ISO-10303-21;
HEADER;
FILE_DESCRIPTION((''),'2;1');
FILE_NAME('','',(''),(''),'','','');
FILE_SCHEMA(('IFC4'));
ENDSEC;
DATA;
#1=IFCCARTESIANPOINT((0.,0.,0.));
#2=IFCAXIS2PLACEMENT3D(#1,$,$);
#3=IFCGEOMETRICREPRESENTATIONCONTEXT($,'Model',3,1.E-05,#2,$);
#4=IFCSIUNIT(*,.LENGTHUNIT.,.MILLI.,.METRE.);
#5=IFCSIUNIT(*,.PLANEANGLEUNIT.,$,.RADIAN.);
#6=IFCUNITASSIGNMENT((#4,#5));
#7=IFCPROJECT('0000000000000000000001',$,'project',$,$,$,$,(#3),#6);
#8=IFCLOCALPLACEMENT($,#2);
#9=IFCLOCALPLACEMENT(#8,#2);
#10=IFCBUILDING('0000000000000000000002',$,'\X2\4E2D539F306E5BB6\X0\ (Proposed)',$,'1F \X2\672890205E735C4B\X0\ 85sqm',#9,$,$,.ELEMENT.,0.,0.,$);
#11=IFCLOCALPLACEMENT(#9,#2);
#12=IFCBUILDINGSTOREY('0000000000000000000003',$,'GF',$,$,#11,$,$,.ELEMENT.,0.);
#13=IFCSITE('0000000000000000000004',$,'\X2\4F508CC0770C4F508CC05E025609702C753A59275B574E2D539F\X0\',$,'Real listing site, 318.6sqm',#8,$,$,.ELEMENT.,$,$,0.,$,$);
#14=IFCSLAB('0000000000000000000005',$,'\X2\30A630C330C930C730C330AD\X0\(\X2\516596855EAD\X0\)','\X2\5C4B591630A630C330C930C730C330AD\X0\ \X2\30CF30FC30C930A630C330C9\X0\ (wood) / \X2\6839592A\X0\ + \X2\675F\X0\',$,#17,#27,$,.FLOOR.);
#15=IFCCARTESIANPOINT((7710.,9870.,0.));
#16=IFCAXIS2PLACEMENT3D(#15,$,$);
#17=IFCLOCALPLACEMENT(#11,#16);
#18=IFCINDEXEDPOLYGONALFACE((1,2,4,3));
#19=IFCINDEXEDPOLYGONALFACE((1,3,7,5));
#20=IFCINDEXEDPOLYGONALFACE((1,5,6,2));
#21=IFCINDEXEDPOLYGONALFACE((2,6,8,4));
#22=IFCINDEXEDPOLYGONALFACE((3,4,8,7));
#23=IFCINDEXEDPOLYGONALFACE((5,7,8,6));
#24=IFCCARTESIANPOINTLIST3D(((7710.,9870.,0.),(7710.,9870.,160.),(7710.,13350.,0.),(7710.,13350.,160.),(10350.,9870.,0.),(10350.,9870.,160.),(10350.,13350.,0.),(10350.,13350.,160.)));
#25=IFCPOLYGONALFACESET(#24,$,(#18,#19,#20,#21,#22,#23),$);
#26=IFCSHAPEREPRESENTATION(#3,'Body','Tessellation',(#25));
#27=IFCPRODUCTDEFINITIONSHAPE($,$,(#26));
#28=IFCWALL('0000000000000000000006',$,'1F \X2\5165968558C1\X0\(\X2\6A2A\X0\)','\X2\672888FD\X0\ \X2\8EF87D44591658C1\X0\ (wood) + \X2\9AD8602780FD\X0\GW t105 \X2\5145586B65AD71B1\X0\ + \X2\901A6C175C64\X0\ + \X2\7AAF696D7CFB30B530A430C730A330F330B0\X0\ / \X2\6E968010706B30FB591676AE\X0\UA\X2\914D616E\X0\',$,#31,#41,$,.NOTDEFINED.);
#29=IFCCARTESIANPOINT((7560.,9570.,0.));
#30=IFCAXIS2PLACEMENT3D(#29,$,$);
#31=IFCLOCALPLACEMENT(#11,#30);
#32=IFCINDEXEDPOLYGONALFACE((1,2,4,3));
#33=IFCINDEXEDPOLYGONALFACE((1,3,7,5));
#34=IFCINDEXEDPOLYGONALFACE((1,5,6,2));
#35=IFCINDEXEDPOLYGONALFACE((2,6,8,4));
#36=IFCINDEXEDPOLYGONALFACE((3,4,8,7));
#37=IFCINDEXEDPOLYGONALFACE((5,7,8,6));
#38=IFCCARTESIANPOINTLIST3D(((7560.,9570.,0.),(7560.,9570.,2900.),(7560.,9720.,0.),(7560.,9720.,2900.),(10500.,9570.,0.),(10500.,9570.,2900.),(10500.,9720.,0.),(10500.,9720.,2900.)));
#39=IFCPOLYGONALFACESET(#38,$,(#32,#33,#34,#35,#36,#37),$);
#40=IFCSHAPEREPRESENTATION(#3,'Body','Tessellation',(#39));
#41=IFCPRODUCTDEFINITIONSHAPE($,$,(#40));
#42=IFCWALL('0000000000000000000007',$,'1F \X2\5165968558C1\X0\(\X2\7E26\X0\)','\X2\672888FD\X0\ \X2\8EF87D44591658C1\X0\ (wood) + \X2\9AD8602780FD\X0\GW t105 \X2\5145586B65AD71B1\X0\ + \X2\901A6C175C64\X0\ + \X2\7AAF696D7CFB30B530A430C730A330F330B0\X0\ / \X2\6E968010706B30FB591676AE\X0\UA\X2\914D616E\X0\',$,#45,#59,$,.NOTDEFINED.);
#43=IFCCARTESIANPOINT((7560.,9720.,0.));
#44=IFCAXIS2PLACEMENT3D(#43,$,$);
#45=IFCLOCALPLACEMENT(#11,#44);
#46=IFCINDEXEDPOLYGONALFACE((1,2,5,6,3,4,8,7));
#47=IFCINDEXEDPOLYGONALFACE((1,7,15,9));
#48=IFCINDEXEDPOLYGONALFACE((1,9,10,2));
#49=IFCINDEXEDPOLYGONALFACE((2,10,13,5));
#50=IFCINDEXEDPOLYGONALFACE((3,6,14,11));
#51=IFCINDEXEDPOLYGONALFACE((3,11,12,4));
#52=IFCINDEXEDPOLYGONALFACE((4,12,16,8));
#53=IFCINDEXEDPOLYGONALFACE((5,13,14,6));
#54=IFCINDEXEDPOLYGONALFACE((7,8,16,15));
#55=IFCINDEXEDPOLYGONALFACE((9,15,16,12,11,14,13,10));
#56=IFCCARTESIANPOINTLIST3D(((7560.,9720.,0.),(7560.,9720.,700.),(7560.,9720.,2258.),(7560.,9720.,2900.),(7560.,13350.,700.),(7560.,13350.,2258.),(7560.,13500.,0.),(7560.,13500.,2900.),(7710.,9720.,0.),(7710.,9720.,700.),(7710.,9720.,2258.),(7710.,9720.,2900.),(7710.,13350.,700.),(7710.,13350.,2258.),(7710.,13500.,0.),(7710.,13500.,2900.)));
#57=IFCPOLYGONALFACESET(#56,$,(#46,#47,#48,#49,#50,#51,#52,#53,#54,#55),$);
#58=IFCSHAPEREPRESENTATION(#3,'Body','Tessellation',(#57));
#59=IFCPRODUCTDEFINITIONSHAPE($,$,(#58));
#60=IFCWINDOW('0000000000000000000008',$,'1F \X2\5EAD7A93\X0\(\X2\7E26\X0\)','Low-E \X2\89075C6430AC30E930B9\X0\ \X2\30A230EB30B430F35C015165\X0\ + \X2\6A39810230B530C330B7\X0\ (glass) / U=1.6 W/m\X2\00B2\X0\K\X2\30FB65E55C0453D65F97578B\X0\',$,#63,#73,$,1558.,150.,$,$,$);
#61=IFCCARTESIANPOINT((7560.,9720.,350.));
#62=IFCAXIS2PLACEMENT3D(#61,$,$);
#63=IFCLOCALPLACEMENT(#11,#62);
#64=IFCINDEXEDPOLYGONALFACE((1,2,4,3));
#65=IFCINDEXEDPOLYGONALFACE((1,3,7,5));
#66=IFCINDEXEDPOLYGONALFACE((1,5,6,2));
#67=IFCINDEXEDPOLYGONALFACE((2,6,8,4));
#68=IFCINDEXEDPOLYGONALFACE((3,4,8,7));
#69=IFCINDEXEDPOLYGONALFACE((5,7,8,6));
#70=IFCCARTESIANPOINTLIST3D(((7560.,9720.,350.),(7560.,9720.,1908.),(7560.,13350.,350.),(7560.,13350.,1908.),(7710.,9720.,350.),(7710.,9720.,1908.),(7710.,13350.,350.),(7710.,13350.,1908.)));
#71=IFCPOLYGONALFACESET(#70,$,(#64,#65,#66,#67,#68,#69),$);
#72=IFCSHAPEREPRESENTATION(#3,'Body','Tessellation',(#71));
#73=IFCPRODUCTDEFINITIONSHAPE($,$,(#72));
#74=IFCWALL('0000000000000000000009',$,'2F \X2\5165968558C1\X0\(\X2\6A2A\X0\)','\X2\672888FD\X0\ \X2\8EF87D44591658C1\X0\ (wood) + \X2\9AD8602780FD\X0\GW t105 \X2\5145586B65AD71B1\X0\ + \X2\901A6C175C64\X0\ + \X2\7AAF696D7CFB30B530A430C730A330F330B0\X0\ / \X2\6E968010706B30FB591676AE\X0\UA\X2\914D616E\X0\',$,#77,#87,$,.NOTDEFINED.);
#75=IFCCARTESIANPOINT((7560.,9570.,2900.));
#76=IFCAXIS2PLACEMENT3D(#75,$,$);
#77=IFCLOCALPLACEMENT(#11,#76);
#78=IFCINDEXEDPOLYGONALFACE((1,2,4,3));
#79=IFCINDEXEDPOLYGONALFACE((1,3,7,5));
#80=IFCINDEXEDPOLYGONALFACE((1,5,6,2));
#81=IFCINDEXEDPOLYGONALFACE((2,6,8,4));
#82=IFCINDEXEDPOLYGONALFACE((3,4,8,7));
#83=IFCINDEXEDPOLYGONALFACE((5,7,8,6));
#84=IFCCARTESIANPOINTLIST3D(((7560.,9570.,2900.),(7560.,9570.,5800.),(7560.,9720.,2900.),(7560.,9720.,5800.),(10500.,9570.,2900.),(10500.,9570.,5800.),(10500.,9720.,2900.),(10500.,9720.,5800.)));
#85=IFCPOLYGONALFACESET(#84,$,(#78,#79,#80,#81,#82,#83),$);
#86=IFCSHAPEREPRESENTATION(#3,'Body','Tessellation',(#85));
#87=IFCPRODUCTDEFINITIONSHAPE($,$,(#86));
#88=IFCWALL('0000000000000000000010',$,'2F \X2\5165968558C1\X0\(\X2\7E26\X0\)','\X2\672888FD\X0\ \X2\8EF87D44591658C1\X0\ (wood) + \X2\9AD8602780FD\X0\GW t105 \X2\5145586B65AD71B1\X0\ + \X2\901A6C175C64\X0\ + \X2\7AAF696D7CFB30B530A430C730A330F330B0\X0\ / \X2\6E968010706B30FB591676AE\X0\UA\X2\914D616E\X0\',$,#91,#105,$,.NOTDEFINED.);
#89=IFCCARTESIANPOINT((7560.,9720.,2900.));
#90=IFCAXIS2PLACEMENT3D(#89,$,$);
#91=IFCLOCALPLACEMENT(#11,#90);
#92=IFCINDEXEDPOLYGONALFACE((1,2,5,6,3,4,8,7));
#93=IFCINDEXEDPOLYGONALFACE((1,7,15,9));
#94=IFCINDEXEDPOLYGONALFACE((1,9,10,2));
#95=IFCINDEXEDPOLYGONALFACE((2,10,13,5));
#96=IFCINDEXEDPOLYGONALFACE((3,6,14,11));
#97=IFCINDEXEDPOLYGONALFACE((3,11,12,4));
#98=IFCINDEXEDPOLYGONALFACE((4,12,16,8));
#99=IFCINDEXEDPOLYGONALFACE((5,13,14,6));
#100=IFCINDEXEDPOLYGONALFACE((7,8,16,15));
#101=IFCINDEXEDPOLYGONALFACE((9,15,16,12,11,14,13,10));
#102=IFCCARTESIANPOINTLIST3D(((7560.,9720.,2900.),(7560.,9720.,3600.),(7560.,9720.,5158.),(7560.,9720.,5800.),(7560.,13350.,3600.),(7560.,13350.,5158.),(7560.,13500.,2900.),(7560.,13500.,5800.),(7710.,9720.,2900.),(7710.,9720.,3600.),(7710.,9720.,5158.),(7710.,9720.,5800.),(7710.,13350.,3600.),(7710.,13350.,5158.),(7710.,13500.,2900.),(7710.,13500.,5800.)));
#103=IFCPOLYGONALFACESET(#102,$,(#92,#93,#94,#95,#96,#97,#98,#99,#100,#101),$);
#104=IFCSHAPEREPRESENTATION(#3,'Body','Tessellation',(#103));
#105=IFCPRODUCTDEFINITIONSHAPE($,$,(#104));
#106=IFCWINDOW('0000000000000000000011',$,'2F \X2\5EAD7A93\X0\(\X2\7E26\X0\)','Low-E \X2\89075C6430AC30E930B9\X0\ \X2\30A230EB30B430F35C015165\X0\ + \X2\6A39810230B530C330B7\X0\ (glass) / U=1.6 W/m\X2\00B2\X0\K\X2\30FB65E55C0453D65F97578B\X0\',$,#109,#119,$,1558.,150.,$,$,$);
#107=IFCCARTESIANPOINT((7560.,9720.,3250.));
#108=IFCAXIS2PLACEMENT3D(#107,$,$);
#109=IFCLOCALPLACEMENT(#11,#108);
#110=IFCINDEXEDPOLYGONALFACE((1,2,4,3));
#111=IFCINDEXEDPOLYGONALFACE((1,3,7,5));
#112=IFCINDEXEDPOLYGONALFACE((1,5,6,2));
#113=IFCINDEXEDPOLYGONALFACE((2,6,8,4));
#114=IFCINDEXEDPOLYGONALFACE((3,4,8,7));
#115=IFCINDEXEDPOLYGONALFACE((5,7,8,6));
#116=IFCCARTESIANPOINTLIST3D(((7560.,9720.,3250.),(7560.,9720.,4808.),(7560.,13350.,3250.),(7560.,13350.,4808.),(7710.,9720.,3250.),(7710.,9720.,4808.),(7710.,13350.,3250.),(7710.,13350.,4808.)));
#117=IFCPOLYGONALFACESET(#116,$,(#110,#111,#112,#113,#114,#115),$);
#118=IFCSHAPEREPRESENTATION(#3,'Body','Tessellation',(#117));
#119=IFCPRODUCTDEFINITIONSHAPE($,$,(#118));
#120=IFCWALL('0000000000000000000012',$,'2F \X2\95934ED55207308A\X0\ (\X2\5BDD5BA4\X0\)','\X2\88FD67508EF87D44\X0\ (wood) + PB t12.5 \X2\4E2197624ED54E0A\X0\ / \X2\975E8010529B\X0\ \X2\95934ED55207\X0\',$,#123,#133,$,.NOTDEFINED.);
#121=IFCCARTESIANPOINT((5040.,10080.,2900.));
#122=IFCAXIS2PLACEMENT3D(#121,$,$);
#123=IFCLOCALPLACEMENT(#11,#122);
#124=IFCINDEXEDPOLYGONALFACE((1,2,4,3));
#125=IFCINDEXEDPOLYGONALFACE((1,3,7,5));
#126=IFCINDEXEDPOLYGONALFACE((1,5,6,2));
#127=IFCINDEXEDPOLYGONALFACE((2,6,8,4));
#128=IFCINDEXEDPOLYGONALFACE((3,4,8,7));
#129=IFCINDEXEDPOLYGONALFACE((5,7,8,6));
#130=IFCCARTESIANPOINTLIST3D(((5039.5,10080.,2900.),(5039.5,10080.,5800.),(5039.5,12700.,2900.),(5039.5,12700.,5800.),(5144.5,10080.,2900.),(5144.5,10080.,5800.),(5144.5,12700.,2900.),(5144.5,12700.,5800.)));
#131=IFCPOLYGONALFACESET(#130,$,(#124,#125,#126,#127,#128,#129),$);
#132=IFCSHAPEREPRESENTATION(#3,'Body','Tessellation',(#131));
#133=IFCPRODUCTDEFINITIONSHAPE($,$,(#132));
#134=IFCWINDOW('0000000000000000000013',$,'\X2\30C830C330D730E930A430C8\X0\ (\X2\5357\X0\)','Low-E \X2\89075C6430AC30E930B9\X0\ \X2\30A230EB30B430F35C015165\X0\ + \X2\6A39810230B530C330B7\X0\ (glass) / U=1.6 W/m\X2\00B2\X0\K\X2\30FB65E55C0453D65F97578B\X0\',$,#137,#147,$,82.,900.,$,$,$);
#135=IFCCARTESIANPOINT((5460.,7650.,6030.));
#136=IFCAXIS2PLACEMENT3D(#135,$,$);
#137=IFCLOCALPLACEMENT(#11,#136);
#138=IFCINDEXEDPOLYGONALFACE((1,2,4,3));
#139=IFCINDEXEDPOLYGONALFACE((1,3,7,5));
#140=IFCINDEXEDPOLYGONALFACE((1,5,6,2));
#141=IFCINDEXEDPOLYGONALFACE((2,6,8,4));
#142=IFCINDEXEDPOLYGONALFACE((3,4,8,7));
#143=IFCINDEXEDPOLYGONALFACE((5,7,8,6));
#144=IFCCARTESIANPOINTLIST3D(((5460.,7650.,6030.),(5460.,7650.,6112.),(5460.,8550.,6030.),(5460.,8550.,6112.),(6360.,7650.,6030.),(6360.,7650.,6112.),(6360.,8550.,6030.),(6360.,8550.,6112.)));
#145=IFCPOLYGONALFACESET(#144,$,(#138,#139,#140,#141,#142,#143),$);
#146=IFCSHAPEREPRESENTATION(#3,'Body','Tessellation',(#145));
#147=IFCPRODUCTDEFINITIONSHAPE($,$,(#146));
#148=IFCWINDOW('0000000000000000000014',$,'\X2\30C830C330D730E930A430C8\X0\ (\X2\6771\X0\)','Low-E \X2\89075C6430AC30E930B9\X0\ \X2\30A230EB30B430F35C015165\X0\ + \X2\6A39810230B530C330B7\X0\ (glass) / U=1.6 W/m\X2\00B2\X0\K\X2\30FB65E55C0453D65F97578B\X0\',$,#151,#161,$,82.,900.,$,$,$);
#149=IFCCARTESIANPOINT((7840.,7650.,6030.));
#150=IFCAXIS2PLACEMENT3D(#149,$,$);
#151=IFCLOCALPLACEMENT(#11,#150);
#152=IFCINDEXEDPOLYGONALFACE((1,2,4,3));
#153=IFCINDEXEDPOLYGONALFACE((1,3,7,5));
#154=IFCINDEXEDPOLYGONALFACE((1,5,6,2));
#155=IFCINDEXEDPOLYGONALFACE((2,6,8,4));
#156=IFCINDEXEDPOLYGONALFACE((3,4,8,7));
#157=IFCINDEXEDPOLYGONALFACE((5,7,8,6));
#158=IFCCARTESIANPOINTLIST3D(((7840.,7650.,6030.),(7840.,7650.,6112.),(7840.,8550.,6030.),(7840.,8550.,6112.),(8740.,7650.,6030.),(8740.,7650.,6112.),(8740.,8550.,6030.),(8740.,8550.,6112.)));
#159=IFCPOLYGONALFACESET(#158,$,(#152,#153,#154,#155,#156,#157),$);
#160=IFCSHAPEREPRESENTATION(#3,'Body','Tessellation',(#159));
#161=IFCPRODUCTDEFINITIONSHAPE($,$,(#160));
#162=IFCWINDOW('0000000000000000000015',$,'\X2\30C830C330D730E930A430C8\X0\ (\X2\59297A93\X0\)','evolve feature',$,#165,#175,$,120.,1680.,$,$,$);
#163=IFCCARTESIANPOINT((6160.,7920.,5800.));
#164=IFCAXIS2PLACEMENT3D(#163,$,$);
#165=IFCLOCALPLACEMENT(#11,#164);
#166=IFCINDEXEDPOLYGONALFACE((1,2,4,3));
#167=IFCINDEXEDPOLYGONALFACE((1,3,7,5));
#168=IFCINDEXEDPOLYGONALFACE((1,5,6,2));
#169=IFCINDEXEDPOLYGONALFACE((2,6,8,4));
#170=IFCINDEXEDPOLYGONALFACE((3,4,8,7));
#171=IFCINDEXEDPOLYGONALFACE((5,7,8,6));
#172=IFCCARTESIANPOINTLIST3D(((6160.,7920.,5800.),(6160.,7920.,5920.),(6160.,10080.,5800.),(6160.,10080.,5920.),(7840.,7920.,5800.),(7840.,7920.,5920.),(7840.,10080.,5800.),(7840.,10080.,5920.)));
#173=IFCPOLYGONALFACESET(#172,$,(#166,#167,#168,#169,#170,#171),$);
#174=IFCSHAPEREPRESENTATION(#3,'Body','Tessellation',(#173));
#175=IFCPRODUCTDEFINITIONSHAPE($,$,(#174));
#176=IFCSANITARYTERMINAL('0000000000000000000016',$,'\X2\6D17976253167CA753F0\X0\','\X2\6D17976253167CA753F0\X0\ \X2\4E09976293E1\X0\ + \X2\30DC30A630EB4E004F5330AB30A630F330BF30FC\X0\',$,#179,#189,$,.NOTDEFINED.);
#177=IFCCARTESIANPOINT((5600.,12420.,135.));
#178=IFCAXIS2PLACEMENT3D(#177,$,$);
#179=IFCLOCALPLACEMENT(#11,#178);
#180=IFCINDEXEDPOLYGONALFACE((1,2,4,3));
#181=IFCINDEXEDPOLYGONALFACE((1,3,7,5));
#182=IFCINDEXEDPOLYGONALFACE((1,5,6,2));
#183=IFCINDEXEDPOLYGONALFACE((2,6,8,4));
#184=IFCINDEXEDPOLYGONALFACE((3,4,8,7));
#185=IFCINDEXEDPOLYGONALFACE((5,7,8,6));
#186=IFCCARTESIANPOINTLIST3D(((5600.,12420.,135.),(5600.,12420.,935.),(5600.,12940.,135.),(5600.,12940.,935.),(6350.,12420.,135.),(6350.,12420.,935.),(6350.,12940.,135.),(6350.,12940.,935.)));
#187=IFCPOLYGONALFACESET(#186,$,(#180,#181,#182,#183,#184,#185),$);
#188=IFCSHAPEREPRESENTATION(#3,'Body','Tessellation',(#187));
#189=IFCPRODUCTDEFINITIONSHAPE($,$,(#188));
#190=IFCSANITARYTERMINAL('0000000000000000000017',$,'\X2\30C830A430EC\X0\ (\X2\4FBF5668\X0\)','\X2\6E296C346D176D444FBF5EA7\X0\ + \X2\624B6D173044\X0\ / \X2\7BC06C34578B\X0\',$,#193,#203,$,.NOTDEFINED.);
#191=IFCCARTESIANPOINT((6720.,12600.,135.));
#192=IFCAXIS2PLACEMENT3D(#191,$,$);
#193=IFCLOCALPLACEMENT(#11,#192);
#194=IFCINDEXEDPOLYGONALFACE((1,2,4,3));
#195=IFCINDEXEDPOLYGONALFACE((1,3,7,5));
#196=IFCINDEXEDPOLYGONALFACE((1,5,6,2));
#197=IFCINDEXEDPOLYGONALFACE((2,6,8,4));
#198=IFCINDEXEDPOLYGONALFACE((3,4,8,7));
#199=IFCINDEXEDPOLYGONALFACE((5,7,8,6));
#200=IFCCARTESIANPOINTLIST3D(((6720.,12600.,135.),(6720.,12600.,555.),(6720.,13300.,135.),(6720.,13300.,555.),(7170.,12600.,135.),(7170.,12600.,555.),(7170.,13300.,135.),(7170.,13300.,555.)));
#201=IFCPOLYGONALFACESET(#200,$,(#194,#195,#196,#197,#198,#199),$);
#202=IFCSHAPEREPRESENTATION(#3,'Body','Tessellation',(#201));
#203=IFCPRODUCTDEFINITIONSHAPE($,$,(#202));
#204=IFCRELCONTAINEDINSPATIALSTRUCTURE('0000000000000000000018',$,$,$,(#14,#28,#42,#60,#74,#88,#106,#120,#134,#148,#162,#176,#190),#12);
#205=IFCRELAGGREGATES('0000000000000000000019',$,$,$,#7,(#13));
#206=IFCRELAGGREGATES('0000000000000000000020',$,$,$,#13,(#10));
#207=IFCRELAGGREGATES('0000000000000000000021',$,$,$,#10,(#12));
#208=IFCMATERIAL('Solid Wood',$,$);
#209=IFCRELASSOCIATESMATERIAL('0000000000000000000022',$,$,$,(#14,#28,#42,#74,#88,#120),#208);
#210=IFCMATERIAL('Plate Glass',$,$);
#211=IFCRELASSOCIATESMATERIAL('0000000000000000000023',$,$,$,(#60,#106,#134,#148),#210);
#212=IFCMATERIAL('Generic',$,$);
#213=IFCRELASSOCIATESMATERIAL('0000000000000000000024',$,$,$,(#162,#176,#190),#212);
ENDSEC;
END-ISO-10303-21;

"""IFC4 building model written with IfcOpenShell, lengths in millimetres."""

from ifc_helpers import new_model, si_unit, frame, frame_2d, origin, place, context, project, spatial, rectangle, extrude, material, element, fill, save


model = new_model("IFC4")

# Units and contexts
model_context = context("Model", 3, precision=1e-05, world=origin())
ifc_project = project(units=[si_unit("LENGTHUNIT", "METRE", prefix="MILLI"), si_unit("PLANEANGLEUNIT", "RADIAN")], contexts=[model_context])

# Site, building, storey
site_placement = place(None, origin())
site = spatial("IfcSite", under=ifc_project, at=site_placement, Name="佐賀県佐賀市嘉瀬町大字中原", ObjectType="Real listing site, 318.6sqm", CompositionType="ELEMENT", RefElevation=0.0)
building_placement = place(site_placement, origin())
building = spatial("IfcBuilding", under=site, at=building_placement, Name="中原の家 (Proposed)", ObjectType="1F 木造平屋 85sqm", CompositionType="ELEMENT", ElevationOfRefHeight=0.0, ElevationOfTerrain=0.0)
storey_placement = place(building_placement, origin())
storey = spatial("IfcBuildingStorey", under=building, at=storey_placement, Name="GF", CompositionType="ELEMENT", Elevation=0.0)

# Slab
ifc_material_1 = material(Name="Solid Wood")
slab_placement = place(storey_placement, frame((7710.0, 9870.0, 0.0)))
element("IfcSlab", 1, at=slab_placement, inside=storey, material=ifc_material_1, Name="ウッドデッキ(入隅庭)", Description="屋外ウッドデッキ ハードウッド (wood) / 根太 + 束", PredefinedType="FLOOR", context=model_context, shape_type="SweptSolid", body=[
    extrude(rectangle(XDim=2640.0, YDim=3480.0, at=frame_2d((1320.0, 1740.0))), frame((7710.0, 9870.0, 0.0)), (0.0, 0.0, 1.0), 160.0),
])

# Wall
wall_1_placement = place(storey_placement, frame((7560.0, 9570.0, 0.0)))
element("IfcWall", 2, at=wall_1_placement, inside=storey, material=ifc_material_1, Name="1F 入隅壁(横)", Description="木製 軸組外壁 (wood) + 高性能GW t105 充填断熱 + 通気層 + 窯業系サイディング / 準耐火・外皮UA配慮", PredefinedType="NOTDEFINED", context=model_context, shape_type="SweptSolid", body=[
    extrude(rectangle(XDim=2940.0, YDim=150.0, at=frame_2d((1470.0, 75.0))), frame((7560.0, 9570.0, 0.0)), (0.0, 0.0, 1.0), 2900.0),
])

# Wall, opening, window
wall_2_placement = place(storey_placement, frame((7560.0, 9720.0, 0.0)))
wall_2 = element("IfcWall", 3, at=wall_2_placement, inside=storey, material=ifc_material_1, Name="1F 入隅壁(縦)", Description="木製 軸組外壁 (wood) + 高性能GW t105 充填断熱 + 通気層 + 窯業系サイディング / 準耐火・外皮UA配慮", PredefinedType="NOTDEFINED", context=model_context, shape_type="SweptSolid", body=[
    extrude(rectangle(XDim=150.0, YDim=3780.0, at=frame_2d((75.0, 1890.0))), frame((7560.0, 9720.0, 0.0)), (0.0, 0.0, 1.0), 2900.0),
])
opening_1_placement = place(storey_placement, frame((7560.0, 9720.0, 350.0)))
opening_1 = element("IfcOpeningElement", 4, at=opening_1_placement, cuts=wall_2, PredefinedType="NOTDEFINED", context=model_context, shape_type="SweptSolid", body=[
    extrude(rectangle(XDim=150.0, YDim=3630.0, at=frame_2d((75.0, 1815.0))), frame((7560.0, 9720.0, 350.0)), (0.0, 0.0, 1.0), 1558.0),
])
ifc_material_2 = material(Name="Plate Glass")
window_1_placement = place(storey_placement, frame((7560.0, 9720.0, 350.0)))
window_1 = element("IfcWindow", 5, at=window_1_placement, inside=storey, material=ifc_material_2, Name="1F 庭窓(縦)", Description="Low-E 複層ガラス アルゴン封入 + 樹脂サッシ (glass) / U=1.6 W/m²K・日射取得型", OverallHeight=1558.0, OverallWidth=150.0, context=model_context, shape_type="SweptSolid", body=[
    extrude(rectangle(XDim=150.0, YDim=3630.0, at=frame_2d((75.0, 1815.0))), frame((7560.0, 9720.0, 350.0)), (0.0, 0.0, 1.0), 1558.0),
])
fill(opening_1, window_1)

# Wall
wall_3_placement = place(storey_placement, frame((7560.0, 9570.0, 2900.0)))
element("IfcWall", 6, at=wall_3_placement, inside=storey, material=ifc_material_1, Name="2F 入隅壁(横)", Description="木製 軸組外壁 (wood) + 高性能GW t105 充填断熱 + 通気層 + 窯業系サイディング / 準耐火・外皮UA配慮", PredefinedType="NOTDEFINED", context=model_context, shape_type="SweptSolid", body=[
    extrude(rectangle(XDim=2940.0, YDim=150.0, at=frame_2d((1470.0, 75.0))), frame((7560.0, 9570.0, 2900.0)), (0.0, 0.0, 1.0), 2900.0),
])

# Wall, opening, window
wall_4_placement = place(storey_placement, frame((7560.0, 9720.0, 2900.0)))
wall_4 = element("IfcWall", 7, at=wall_4_placement, inside=storey, material=ifc_material_1, Name="2F 入隅壁(縦)", Description="木製 軸組外壁 (wood) + 高性能GW t105 充填断熱 + 通気層 + 窯業系サイディング / 準耐火・外皮UA配慮", PredefinedType="NOTDEFINED", context=model_context, shape_type="SweptSolid", body=[
    extrude(rectangle(XDim=150.0, YDim=3780.0, at=frame_2d((75.0, 1890.0))), frame((7560.0, 9720.0, 2900.0)), (0.0, 0.0, 1.0), 2900.0),
])
opening_2_placement = place(storey_placement, frame((7560.0, 9720.0, 3250.0)))
opening_2 = element("IfcOpeningElement", 8, at=opening_2_placement, cuts=wall_4, PredefinedType="NOTDEFINED", context=model_context, shape_type="SweptSolid", body=[
    extrude(rectangle(XDim=150.0, YDim=3630.0, at=frame_2d((75.0, 1815.0))), frame((7560.0, 9720.0, 3250.0)), (0.0, 0.0, 1.0), 1558.0),
])
window_2_placement = place(storey_placement, frame((7560.0, 9720.0, 3250.0)))
window_2 = element("IfcWindow", 9, at=window_2_placement, inside=storey, material=ifc_material_2, Name="2F 庭窓(縦)", Description="Low-E 複層ガラス アルゴン封入 + 樹脂サッシ (glass) / U=1.6 W/m²K・日射取得型", OverallHeight=1558.0, OverallWidth=150.0, context=model_context, shape_type="SweptSolid", body=[
    extrude(rectangle(XDim=150.0, YDim=3630.0, at=frame_2d((75.0, 1815.0))), frame((7560.0, 9720.0, 3250.0)), (0.0, 0.0, 1.0), 1558.0),
])
fill(opening_2, window_2)

# Wall
wall_5_placement = place(storey_placement, frame((5040.0, 10080.0, 2900.0)))
element("IfcWall", 10, at=wall_5_placement, inside=storey, material=ifc_material_1, Name="2F 間仕切り (寝室)", Description="製材軸組 (wood) + PB t12.5 両面仕上 / 非耐力 間仕切", PredefinedType="NOTDEFINED", context=model_context, shape_type="SweptSolid", body=[
    extrude(rectangle(XDim=105.0, YDim=2620.0, at=frame_2d((52.0, 1310.0))), frame((5040.0, 10080.0, 2900.0)), (0.0, 0.0, 1.0), 2900.0),
])

# Windows
window_3_placement = place(storey_placement, frame((5460.0, 7650.0, 6030.0)))
element("IfcWindow", 11, at=window_3_placement, inside=storey, material=ifc_material_2, Name="トップライト (南)", Description="Low-E 複層ガラス アルゴン封入 + 樹脂サッシ (glass) / U=1.6 W/m²K・日射取得型", OverallHeight=82.0, OverallWidth=900.0, context=model_context, shape_type="SweptSolid", body=[
    extrude(rectangle(XDim=900.0, YDim=900.0, at=frame_2d((450.0, 450.0))), frame((5460.0, 7650.0, 6030.0)), (0.0, 0.0, 1.0), 82.0),
])
window_4_placement = place(storey_placement, frame((7840.0, 7650.0, 6030.0)))
element("IfcWindow", 12, at=window_4_placement, inside=storey, material=ifc_material_2, Name="トップライト (東)", Description="Low-E 複層ガラス アルゴン封入 + 樹脂サッシ (glass) / U=1.6 W/m²K・日射取得型", OverallHeight=82.0, OverallWidth=900.0, context=model_context, shape_type="SweptSolid", body=[
    extrude(rectangle(XDim=900.0, YDim=900.0, at=frame_2d((450.0, 450.0))), frame((7840.0, 7650.0, 6030.0)), (0.0, 0.0, 1.0), 82.0),
])
ifc_material_3 = material(Name="Generic")
window_5_placement = place(storey_placement, frame((6160.0, 7920.0, 5800.0)))
element("IfcWindow", 13, at=window_5_placement, inside=storey, material=ifc_material_3, Name="トップライト (天窓)", Description="evolve feature", OverallHeight=120.0, OverallWidth=1680.0, context=model_context, shape_type="SweptSolid", body=[
    extrude(rectangle(XDim=1680.0, YDim=2160.0, at=frame_2d((840.0, 1080.0))), frame((6160.0, 7920.0, 5800.0)), (0.0, 0.0, 1.0), 120.0),
])

# Sanitary terminals
sanitary_terminal_1_placement = place(storey_placement, frame((5600.0, 12420.0, 135.0)))
element("IfcSanitaryTerminal", 14, at=sanitary_terminal_1_placement, inside=storey, material=ifc_material_3, Name="洗面化粧台", Description="洗面化粧台 三面鏡 + ボウル一体カウンター", PredefinedType="NOTDEFINED", context=model_context, shape_type="SweptSolid", body=[
    extrude(rectangle(XDim=750.0, YDim=520.0, at=frame_2d((375.0, 260.0))), frame((5600.0, 12420.0, 135.0)), (0.0, 0.0, 1.0), 800.0),
])
sanitary_terminal_2_placement = place(storey_placement, frame((6720.0, 12600.0, 135.0)))
element("IfcSanitaryTerminal", 15, at=sanitary_terminal_2_placement, inside=storey, material=ifc_material_3, Name="トイレ (便器)", Description="温水洗浄便座 + 手洗い / 節水型", PredefinedType="NOTDEFINED", context=model_context, shape_type="SweptSolid", body=[
    extrude(rectangle(XDim=450.0, YDim=700.0, at=frame_2d((225.0, 350.0))), frame((6720.0, 12600.0, 135.0)), (0.0, 0.0, 1.0), 420.0),
])

save(model, "model.ifc")
